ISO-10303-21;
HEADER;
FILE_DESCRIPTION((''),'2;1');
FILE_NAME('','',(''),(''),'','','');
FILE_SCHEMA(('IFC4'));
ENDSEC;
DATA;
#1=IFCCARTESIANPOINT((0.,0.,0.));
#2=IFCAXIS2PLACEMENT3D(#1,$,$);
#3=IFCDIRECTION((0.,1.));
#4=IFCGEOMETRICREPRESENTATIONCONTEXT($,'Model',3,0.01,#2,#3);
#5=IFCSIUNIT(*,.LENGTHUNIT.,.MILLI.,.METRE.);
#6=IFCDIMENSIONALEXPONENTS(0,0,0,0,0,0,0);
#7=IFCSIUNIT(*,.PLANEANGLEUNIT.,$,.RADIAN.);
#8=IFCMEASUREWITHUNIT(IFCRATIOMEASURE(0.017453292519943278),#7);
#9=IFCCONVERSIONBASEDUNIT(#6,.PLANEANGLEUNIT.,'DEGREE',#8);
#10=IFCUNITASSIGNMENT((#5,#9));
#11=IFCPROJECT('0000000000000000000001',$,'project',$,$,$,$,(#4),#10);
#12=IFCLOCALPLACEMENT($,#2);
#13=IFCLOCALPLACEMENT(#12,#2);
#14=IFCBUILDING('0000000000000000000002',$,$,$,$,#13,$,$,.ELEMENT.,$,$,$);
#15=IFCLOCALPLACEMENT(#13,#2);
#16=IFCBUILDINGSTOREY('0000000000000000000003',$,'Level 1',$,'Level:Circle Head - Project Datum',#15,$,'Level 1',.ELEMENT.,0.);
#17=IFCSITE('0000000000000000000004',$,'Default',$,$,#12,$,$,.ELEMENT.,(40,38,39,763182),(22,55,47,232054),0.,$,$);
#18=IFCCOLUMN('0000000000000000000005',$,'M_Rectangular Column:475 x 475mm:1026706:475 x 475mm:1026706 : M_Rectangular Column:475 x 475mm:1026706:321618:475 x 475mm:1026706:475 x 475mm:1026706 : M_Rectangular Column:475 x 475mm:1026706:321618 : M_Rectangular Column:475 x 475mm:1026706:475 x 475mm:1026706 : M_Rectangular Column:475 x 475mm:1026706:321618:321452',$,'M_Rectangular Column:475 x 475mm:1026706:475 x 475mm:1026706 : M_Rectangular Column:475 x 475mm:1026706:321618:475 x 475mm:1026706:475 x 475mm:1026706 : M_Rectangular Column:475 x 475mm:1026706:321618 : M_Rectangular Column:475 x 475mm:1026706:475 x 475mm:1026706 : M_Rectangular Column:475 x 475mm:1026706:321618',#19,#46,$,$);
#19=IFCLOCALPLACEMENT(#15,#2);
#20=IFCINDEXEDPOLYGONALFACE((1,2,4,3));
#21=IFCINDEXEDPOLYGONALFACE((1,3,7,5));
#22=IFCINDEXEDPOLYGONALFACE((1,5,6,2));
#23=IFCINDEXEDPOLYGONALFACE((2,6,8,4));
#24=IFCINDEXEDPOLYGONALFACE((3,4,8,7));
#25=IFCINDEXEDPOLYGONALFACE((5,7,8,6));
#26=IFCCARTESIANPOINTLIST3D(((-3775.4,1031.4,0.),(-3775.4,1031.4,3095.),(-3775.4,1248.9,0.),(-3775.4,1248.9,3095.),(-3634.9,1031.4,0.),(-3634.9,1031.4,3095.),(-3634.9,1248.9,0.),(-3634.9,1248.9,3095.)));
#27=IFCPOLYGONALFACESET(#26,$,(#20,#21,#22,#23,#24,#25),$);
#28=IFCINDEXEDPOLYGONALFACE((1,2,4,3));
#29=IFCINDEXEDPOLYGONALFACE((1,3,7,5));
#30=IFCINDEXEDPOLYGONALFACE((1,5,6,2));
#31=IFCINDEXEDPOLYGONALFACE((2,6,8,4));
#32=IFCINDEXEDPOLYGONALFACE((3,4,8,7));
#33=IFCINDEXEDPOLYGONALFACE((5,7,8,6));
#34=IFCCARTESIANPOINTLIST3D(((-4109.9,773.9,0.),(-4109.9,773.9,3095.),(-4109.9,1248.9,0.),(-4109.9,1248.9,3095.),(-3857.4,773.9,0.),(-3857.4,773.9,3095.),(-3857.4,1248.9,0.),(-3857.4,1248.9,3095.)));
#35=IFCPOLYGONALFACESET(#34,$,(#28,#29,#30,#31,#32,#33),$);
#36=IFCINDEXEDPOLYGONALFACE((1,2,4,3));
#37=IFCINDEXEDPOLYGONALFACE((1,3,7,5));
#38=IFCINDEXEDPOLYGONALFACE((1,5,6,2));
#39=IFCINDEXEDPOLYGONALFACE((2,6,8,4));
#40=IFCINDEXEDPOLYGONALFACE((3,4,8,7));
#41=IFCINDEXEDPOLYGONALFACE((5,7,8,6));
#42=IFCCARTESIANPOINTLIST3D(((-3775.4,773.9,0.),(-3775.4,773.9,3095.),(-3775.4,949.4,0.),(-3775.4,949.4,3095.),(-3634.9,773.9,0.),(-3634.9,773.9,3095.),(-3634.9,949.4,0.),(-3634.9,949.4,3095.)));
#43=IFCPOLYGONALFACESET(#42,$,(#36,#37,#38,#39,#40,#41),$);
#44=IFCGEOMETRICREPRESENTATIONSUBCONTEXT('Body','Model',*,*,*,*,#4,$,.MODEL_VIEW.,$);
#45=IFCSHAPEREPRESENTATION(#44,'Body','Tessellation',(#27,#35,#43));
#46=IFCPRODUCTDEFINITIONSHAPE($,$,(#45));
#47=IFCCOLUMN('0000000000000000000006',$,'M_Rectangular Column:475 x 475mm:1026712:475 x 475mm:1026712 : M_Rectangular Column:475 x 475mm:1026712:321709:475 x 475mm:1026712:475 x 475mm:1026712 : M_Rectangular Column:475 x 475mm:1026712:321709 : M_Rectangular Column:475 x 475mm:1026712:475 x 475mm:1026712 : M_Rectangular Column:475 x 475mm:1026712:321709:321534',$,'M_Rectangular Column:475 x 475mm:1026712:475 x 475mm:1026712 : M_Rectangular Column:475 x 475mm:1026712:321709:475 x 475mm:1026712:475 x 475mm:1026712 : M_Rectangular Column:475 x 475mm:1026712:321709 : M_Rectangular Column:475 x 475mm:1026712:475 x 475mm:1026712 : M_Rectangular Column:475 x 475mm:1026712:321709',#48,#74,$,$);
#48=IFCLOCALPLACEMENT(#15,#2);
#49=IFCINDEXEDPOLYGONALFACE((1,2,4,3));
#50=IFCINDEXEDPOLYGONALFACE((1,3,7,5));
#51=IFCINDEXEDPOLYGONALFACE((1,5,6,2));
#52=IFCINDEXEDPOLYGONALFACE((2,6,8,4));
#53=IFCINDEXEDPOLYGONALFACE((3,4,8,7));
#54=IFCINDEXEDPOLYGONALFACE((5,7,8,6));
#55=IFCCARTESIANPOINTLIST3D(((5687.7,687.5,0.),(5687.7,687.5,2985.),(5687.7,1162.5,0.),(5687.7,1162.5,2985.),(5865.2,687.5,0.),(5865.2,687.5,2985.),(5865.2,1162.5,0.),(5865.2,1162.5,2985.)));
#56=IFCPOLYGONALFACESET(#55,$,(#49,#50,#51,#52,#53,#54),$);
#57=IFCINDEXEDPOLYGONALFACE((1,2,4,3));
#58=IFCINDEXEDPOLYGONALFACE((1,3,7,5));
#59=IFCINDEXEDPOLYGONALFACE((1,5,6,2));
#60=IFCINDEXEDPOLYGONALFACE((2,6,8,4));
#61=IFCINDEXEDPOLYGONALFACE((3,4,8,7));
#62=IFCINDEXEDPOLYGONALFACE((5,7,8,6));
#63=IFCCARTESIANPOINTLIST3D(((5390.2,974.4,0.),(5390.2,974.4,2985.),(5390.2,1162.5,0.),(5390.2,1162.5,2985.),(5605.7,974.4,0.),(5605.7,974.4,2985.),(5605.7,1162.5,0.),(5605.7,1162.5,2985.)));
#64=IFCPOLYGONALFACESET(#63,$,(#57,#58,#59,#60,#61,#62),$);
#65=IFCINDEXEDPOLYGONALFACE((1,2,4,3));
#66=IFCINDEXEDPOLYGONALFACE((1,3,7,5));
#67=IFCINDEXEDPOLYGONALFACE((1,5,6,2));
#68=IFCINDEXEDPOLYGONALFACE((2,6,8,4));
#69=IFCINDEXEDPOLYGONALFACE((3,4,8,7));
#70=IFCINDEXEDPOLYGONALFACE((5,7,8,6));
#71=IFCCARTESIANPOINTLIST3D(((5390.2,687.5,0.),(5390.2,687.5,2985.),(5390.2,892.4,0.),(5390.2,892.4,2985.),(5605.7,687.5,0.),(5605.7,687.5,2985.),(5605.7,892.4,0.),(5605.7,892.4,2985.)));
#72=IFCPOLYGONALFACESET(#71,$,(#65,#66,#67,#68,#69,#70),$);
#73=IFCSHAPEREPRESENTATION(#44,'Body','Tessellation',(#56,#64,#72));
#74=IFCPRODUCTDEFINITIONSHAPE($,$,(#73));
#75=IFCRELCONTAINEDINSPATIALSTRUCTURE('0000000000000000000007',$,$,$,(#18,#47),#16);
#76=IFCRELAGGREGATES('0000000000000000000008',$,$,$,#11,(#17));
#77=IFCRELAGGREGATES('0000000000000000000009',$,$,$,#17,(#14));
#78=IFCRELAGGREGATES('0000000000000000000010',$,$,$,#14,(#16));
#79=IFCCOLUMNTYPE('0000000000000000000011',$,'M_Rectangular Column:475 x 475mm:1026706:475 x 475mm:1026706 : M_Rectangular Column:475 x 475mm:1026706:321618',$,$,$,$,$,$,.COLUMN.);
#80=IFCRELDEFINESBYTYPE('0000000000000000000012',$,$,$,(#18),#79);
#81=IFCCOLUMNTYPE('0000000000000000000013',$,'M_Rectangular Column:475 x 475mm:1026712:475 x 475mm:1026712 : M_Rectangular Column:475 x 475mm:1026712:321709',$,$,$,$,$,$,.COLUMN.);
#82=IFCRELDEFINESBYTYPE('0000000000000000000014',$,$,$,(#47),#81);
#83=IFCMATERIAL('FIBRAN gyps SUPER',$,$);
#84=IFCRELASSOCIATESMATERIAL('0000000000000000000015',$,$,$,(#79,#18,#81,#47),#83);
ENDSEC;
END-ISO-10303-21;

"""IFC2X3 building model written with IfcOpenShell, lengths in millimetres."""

from ifc_helpers import new_model, entity, si_unit, converted_unit, direction, frame, frame_2d, origin, origin_2d_with_axis, place, context, subcontext, project, spatial, rectangle, extrude, source, transform, mapped, material, type_object, type_shapes, element, save


model = new_model("IFC2X3")

# Units and contexts
model_context = context("Model", 3, precision=0.01, world=origin(), true_north=direction((0.0, 1.0)))
body_context = subcontext(model_context, "Body", "Model", "MODEL_VIEW")
ifc_project = project(units=[si_unit("LENGTHUNIT", "METRE", prefix="MILLI"), converted_unit("PLANEANGLEUNIT", "DEGREE", entity("IfcRatioMeasure", 0.017453292519943278), si_unit("PLANEANGLEUNIT", "RADIAN"), dimensions=[0, 0, 0, 0, 0, 0, 0])], contexts=[model_context])

# Site, building, storey
site_placement = place(None, origin())
site = spatial("IfcSite", under=ifc_project, at=site_placement, Name="Default", CompositionType="ELEMENT", RefLatitude=(40, 38, 39, 763182), RefLongitude=(22, 55, 47, 232054), RefElevation=0.0)
building_placement = place(site_placement, origin())
building = spatial("IfcBuilding", under=site, at=building_placement, CompositionType="ELEMENT")
storey_placement = place(building_placement, origin())
storey = spatial("IfcBuildingStorey", under=building, at=storey_placement, Name="Level 1", ObjectType="Level:Circle Head - Project Datum", LongName="Level 1", CompositionType="ELEMENT", Elevation=0.0)

# Columns
ifc_material_1 = material(Name="FIBRAN gyps SUPER")
column_type_1 = type_object("IfcColumnType", Name="M_Rectangular Column:475 x 475mm:1026706:475 x 475mm:1026706 : M_Rectangular Column:475 x 475mm:1026706:321618", PredefinedType="COLUMN", material=ifc_material_1)
shared_shape_1 = source(origin(), body_context, "Body", "SweptSolid", [
    extrude(rectangle(XDim=217.5, YDim=140.5, at=frame_2d((0.0, 0.0), x_axis=(1.0, 0.0))), frame((-3705.1, 1140.1, 0.0), z_axis=(0.0, 0.0, 1.0), x_axis=(0.0, -1.0, 0.0)), (0.0, 0.0, 1.0), 3095.0),
    extrude(rectangle(XDim=475.0, YDim=252.5, at=frame_2d((0.0, 0.0), x_axis=(1.0, 0.0))), frame((-3983.6, 1011.4, 0.0), z_axis=(0.0, 0.0, 1.0), x_axis=(0.0, -1.0, 0.0)), (0.0, 0.0, 1.0), 3095.0),
    extrude(rectangle(XDim=175.5, YDim=140.5, at=frame_2d((0.0, 0.0), x_axis=(1.0, 0.0))), frame((-3705.1, 861.6, 0.0), z_axis=(0.0, 0.0, 1.0), x_axis=(0.0, -1.0, 0.0)), (0.0, 0.0, 1.0), 3095.0),
])
type_shapes(column_type_1, [shared_shape_1])
column_1_placement = place(storey_placement, origin())
element("IfcColumn", 1, at=column_1_placement, inside=storey, type_object=column_type_1, material=ifc_material_1, Name="M_Rectangular Column:475 x 475mm:1026706:475 x 475mm:1026706 : M_Rectangular Column:475 x 475mm:1026706:321618:475 x 475mm:1026706:475 x 475mm:1026706 : M_Rectangular Column:475 x 475mm:1026706:321618 : M_Rectangular Column:475 x 475mm:1026706:475 x 475mm:1026706 : M_Rectangular Column:475 x 475mm:1026706:321618:321452", ObjectType="M_Rectangular Column:475 x 475mm:1026706:475 x 475mm:1026706 : M_Rectangular Column:475 x 475mm:1026706:321618:475 x 475mm:1026706:475 x 475mm:1026706 : M_Rectangular Column:475 x 475mm:1026706:321618 : M_Rectangular Column:475 x 475mm:1026706:475 x 475mm:1026706 : M_Rectangular Column:475 x 475mm:1026706:321618", context=body_context, shape_type="MappedRepresentation", body=[
    mapped(shared_shape_1, transform((0.0, 0.0, 0.0), scale=1.0)),
])
column_type_2 = type_object("IfcColumnType", Name="M_Rectangular Column:475 x 475mm:1026712:475 x 475mm:1026712 : M_Rectangular Column:475 x 475mm:1026712:321709", PredefinedType="COLUMN", material=ifc_material_1)
shared_shape_2 = source(origin(), body_context, "Body", "SweptSolid", [
    extrude(rectangle(XDim=475.0, YDim=177.5, at=frame_2d((0.0, 0.0), x_axis=(1.0, 0.0))), frame((5776.5, 925.0, 0.0), z_axis=(0.0, 0.0, 1.0), x_axis=(0.0, -1.0, 0.0)), (0.0, 0.0, 1.0), 2985.0),
    extrude(rectangle(XDim=188.1, YDim=215.5, at=frame_2d((0.0, 0.0), x_axis=(1.0, 0.0))), frame((5498.0, 1068.5, 0.0), z_axis=(0.0, 0.0, 1.0), x_axis=(0.0, -1.0, 0.0)), (0.0, 0.0, 1.0), 2985.0),
    extrude(rectangle(XDim=204.9, YDim=215.5, at=origin_2d_with_axis()), frame((5498.0, 790.0, 0.0), z_axis=(0.0, 0.0, 1.0), x_axis=(0.0, -1.0, 0.0)), (0.0, 0.0, 1.0), 2985.0),
])
type_shapes(column_type_2, [shared_shape_2])
column_2_placement = place(storey_placement, origin())
element("IfcColumn", 2, at=column_2_placement, inside=storey, type_object=column_type_2, material=ifc_material_1, Name="M_Rectangular Column:475 x 475mm:1026712:475 x 475mm:1026712 : M_Rectangular Column:475 x 475mm:1026712:321709:475 x 475mm:1026712:475 x 475mm:1026712 : M_Rectangular Column:475 x 475mm:1026712:321709 : M_Rectangular Column:475 x 475mm:1026712:475 x 475mm:1026712 : M_Rectangular Column:475 x 475mm:1026712:321709:321534", ObjectType="M_Rectangular Column:475 x 475mm:1026712:475 x 475mm:1026712 : M_Rectangular Column:475 x 475mm:1026712:321709:475 x 475mm:1026712:475 x 475mm:1026712 : M_Rectangular Column:475 x 475mm:1026712:321709 : M_Rectangular Column:475 x 475mm:1026712:475 x 475mm:1026712 : M_Rectangular Column:475 x 475mm:1026712:321709", context=body_context, shape_type="MappedRepresentation", body=[
    mapped(shared_shape_2, transform((0.0, 0.0, 0.0), scale=1.0)),
])

save(model, "model.ifc")
